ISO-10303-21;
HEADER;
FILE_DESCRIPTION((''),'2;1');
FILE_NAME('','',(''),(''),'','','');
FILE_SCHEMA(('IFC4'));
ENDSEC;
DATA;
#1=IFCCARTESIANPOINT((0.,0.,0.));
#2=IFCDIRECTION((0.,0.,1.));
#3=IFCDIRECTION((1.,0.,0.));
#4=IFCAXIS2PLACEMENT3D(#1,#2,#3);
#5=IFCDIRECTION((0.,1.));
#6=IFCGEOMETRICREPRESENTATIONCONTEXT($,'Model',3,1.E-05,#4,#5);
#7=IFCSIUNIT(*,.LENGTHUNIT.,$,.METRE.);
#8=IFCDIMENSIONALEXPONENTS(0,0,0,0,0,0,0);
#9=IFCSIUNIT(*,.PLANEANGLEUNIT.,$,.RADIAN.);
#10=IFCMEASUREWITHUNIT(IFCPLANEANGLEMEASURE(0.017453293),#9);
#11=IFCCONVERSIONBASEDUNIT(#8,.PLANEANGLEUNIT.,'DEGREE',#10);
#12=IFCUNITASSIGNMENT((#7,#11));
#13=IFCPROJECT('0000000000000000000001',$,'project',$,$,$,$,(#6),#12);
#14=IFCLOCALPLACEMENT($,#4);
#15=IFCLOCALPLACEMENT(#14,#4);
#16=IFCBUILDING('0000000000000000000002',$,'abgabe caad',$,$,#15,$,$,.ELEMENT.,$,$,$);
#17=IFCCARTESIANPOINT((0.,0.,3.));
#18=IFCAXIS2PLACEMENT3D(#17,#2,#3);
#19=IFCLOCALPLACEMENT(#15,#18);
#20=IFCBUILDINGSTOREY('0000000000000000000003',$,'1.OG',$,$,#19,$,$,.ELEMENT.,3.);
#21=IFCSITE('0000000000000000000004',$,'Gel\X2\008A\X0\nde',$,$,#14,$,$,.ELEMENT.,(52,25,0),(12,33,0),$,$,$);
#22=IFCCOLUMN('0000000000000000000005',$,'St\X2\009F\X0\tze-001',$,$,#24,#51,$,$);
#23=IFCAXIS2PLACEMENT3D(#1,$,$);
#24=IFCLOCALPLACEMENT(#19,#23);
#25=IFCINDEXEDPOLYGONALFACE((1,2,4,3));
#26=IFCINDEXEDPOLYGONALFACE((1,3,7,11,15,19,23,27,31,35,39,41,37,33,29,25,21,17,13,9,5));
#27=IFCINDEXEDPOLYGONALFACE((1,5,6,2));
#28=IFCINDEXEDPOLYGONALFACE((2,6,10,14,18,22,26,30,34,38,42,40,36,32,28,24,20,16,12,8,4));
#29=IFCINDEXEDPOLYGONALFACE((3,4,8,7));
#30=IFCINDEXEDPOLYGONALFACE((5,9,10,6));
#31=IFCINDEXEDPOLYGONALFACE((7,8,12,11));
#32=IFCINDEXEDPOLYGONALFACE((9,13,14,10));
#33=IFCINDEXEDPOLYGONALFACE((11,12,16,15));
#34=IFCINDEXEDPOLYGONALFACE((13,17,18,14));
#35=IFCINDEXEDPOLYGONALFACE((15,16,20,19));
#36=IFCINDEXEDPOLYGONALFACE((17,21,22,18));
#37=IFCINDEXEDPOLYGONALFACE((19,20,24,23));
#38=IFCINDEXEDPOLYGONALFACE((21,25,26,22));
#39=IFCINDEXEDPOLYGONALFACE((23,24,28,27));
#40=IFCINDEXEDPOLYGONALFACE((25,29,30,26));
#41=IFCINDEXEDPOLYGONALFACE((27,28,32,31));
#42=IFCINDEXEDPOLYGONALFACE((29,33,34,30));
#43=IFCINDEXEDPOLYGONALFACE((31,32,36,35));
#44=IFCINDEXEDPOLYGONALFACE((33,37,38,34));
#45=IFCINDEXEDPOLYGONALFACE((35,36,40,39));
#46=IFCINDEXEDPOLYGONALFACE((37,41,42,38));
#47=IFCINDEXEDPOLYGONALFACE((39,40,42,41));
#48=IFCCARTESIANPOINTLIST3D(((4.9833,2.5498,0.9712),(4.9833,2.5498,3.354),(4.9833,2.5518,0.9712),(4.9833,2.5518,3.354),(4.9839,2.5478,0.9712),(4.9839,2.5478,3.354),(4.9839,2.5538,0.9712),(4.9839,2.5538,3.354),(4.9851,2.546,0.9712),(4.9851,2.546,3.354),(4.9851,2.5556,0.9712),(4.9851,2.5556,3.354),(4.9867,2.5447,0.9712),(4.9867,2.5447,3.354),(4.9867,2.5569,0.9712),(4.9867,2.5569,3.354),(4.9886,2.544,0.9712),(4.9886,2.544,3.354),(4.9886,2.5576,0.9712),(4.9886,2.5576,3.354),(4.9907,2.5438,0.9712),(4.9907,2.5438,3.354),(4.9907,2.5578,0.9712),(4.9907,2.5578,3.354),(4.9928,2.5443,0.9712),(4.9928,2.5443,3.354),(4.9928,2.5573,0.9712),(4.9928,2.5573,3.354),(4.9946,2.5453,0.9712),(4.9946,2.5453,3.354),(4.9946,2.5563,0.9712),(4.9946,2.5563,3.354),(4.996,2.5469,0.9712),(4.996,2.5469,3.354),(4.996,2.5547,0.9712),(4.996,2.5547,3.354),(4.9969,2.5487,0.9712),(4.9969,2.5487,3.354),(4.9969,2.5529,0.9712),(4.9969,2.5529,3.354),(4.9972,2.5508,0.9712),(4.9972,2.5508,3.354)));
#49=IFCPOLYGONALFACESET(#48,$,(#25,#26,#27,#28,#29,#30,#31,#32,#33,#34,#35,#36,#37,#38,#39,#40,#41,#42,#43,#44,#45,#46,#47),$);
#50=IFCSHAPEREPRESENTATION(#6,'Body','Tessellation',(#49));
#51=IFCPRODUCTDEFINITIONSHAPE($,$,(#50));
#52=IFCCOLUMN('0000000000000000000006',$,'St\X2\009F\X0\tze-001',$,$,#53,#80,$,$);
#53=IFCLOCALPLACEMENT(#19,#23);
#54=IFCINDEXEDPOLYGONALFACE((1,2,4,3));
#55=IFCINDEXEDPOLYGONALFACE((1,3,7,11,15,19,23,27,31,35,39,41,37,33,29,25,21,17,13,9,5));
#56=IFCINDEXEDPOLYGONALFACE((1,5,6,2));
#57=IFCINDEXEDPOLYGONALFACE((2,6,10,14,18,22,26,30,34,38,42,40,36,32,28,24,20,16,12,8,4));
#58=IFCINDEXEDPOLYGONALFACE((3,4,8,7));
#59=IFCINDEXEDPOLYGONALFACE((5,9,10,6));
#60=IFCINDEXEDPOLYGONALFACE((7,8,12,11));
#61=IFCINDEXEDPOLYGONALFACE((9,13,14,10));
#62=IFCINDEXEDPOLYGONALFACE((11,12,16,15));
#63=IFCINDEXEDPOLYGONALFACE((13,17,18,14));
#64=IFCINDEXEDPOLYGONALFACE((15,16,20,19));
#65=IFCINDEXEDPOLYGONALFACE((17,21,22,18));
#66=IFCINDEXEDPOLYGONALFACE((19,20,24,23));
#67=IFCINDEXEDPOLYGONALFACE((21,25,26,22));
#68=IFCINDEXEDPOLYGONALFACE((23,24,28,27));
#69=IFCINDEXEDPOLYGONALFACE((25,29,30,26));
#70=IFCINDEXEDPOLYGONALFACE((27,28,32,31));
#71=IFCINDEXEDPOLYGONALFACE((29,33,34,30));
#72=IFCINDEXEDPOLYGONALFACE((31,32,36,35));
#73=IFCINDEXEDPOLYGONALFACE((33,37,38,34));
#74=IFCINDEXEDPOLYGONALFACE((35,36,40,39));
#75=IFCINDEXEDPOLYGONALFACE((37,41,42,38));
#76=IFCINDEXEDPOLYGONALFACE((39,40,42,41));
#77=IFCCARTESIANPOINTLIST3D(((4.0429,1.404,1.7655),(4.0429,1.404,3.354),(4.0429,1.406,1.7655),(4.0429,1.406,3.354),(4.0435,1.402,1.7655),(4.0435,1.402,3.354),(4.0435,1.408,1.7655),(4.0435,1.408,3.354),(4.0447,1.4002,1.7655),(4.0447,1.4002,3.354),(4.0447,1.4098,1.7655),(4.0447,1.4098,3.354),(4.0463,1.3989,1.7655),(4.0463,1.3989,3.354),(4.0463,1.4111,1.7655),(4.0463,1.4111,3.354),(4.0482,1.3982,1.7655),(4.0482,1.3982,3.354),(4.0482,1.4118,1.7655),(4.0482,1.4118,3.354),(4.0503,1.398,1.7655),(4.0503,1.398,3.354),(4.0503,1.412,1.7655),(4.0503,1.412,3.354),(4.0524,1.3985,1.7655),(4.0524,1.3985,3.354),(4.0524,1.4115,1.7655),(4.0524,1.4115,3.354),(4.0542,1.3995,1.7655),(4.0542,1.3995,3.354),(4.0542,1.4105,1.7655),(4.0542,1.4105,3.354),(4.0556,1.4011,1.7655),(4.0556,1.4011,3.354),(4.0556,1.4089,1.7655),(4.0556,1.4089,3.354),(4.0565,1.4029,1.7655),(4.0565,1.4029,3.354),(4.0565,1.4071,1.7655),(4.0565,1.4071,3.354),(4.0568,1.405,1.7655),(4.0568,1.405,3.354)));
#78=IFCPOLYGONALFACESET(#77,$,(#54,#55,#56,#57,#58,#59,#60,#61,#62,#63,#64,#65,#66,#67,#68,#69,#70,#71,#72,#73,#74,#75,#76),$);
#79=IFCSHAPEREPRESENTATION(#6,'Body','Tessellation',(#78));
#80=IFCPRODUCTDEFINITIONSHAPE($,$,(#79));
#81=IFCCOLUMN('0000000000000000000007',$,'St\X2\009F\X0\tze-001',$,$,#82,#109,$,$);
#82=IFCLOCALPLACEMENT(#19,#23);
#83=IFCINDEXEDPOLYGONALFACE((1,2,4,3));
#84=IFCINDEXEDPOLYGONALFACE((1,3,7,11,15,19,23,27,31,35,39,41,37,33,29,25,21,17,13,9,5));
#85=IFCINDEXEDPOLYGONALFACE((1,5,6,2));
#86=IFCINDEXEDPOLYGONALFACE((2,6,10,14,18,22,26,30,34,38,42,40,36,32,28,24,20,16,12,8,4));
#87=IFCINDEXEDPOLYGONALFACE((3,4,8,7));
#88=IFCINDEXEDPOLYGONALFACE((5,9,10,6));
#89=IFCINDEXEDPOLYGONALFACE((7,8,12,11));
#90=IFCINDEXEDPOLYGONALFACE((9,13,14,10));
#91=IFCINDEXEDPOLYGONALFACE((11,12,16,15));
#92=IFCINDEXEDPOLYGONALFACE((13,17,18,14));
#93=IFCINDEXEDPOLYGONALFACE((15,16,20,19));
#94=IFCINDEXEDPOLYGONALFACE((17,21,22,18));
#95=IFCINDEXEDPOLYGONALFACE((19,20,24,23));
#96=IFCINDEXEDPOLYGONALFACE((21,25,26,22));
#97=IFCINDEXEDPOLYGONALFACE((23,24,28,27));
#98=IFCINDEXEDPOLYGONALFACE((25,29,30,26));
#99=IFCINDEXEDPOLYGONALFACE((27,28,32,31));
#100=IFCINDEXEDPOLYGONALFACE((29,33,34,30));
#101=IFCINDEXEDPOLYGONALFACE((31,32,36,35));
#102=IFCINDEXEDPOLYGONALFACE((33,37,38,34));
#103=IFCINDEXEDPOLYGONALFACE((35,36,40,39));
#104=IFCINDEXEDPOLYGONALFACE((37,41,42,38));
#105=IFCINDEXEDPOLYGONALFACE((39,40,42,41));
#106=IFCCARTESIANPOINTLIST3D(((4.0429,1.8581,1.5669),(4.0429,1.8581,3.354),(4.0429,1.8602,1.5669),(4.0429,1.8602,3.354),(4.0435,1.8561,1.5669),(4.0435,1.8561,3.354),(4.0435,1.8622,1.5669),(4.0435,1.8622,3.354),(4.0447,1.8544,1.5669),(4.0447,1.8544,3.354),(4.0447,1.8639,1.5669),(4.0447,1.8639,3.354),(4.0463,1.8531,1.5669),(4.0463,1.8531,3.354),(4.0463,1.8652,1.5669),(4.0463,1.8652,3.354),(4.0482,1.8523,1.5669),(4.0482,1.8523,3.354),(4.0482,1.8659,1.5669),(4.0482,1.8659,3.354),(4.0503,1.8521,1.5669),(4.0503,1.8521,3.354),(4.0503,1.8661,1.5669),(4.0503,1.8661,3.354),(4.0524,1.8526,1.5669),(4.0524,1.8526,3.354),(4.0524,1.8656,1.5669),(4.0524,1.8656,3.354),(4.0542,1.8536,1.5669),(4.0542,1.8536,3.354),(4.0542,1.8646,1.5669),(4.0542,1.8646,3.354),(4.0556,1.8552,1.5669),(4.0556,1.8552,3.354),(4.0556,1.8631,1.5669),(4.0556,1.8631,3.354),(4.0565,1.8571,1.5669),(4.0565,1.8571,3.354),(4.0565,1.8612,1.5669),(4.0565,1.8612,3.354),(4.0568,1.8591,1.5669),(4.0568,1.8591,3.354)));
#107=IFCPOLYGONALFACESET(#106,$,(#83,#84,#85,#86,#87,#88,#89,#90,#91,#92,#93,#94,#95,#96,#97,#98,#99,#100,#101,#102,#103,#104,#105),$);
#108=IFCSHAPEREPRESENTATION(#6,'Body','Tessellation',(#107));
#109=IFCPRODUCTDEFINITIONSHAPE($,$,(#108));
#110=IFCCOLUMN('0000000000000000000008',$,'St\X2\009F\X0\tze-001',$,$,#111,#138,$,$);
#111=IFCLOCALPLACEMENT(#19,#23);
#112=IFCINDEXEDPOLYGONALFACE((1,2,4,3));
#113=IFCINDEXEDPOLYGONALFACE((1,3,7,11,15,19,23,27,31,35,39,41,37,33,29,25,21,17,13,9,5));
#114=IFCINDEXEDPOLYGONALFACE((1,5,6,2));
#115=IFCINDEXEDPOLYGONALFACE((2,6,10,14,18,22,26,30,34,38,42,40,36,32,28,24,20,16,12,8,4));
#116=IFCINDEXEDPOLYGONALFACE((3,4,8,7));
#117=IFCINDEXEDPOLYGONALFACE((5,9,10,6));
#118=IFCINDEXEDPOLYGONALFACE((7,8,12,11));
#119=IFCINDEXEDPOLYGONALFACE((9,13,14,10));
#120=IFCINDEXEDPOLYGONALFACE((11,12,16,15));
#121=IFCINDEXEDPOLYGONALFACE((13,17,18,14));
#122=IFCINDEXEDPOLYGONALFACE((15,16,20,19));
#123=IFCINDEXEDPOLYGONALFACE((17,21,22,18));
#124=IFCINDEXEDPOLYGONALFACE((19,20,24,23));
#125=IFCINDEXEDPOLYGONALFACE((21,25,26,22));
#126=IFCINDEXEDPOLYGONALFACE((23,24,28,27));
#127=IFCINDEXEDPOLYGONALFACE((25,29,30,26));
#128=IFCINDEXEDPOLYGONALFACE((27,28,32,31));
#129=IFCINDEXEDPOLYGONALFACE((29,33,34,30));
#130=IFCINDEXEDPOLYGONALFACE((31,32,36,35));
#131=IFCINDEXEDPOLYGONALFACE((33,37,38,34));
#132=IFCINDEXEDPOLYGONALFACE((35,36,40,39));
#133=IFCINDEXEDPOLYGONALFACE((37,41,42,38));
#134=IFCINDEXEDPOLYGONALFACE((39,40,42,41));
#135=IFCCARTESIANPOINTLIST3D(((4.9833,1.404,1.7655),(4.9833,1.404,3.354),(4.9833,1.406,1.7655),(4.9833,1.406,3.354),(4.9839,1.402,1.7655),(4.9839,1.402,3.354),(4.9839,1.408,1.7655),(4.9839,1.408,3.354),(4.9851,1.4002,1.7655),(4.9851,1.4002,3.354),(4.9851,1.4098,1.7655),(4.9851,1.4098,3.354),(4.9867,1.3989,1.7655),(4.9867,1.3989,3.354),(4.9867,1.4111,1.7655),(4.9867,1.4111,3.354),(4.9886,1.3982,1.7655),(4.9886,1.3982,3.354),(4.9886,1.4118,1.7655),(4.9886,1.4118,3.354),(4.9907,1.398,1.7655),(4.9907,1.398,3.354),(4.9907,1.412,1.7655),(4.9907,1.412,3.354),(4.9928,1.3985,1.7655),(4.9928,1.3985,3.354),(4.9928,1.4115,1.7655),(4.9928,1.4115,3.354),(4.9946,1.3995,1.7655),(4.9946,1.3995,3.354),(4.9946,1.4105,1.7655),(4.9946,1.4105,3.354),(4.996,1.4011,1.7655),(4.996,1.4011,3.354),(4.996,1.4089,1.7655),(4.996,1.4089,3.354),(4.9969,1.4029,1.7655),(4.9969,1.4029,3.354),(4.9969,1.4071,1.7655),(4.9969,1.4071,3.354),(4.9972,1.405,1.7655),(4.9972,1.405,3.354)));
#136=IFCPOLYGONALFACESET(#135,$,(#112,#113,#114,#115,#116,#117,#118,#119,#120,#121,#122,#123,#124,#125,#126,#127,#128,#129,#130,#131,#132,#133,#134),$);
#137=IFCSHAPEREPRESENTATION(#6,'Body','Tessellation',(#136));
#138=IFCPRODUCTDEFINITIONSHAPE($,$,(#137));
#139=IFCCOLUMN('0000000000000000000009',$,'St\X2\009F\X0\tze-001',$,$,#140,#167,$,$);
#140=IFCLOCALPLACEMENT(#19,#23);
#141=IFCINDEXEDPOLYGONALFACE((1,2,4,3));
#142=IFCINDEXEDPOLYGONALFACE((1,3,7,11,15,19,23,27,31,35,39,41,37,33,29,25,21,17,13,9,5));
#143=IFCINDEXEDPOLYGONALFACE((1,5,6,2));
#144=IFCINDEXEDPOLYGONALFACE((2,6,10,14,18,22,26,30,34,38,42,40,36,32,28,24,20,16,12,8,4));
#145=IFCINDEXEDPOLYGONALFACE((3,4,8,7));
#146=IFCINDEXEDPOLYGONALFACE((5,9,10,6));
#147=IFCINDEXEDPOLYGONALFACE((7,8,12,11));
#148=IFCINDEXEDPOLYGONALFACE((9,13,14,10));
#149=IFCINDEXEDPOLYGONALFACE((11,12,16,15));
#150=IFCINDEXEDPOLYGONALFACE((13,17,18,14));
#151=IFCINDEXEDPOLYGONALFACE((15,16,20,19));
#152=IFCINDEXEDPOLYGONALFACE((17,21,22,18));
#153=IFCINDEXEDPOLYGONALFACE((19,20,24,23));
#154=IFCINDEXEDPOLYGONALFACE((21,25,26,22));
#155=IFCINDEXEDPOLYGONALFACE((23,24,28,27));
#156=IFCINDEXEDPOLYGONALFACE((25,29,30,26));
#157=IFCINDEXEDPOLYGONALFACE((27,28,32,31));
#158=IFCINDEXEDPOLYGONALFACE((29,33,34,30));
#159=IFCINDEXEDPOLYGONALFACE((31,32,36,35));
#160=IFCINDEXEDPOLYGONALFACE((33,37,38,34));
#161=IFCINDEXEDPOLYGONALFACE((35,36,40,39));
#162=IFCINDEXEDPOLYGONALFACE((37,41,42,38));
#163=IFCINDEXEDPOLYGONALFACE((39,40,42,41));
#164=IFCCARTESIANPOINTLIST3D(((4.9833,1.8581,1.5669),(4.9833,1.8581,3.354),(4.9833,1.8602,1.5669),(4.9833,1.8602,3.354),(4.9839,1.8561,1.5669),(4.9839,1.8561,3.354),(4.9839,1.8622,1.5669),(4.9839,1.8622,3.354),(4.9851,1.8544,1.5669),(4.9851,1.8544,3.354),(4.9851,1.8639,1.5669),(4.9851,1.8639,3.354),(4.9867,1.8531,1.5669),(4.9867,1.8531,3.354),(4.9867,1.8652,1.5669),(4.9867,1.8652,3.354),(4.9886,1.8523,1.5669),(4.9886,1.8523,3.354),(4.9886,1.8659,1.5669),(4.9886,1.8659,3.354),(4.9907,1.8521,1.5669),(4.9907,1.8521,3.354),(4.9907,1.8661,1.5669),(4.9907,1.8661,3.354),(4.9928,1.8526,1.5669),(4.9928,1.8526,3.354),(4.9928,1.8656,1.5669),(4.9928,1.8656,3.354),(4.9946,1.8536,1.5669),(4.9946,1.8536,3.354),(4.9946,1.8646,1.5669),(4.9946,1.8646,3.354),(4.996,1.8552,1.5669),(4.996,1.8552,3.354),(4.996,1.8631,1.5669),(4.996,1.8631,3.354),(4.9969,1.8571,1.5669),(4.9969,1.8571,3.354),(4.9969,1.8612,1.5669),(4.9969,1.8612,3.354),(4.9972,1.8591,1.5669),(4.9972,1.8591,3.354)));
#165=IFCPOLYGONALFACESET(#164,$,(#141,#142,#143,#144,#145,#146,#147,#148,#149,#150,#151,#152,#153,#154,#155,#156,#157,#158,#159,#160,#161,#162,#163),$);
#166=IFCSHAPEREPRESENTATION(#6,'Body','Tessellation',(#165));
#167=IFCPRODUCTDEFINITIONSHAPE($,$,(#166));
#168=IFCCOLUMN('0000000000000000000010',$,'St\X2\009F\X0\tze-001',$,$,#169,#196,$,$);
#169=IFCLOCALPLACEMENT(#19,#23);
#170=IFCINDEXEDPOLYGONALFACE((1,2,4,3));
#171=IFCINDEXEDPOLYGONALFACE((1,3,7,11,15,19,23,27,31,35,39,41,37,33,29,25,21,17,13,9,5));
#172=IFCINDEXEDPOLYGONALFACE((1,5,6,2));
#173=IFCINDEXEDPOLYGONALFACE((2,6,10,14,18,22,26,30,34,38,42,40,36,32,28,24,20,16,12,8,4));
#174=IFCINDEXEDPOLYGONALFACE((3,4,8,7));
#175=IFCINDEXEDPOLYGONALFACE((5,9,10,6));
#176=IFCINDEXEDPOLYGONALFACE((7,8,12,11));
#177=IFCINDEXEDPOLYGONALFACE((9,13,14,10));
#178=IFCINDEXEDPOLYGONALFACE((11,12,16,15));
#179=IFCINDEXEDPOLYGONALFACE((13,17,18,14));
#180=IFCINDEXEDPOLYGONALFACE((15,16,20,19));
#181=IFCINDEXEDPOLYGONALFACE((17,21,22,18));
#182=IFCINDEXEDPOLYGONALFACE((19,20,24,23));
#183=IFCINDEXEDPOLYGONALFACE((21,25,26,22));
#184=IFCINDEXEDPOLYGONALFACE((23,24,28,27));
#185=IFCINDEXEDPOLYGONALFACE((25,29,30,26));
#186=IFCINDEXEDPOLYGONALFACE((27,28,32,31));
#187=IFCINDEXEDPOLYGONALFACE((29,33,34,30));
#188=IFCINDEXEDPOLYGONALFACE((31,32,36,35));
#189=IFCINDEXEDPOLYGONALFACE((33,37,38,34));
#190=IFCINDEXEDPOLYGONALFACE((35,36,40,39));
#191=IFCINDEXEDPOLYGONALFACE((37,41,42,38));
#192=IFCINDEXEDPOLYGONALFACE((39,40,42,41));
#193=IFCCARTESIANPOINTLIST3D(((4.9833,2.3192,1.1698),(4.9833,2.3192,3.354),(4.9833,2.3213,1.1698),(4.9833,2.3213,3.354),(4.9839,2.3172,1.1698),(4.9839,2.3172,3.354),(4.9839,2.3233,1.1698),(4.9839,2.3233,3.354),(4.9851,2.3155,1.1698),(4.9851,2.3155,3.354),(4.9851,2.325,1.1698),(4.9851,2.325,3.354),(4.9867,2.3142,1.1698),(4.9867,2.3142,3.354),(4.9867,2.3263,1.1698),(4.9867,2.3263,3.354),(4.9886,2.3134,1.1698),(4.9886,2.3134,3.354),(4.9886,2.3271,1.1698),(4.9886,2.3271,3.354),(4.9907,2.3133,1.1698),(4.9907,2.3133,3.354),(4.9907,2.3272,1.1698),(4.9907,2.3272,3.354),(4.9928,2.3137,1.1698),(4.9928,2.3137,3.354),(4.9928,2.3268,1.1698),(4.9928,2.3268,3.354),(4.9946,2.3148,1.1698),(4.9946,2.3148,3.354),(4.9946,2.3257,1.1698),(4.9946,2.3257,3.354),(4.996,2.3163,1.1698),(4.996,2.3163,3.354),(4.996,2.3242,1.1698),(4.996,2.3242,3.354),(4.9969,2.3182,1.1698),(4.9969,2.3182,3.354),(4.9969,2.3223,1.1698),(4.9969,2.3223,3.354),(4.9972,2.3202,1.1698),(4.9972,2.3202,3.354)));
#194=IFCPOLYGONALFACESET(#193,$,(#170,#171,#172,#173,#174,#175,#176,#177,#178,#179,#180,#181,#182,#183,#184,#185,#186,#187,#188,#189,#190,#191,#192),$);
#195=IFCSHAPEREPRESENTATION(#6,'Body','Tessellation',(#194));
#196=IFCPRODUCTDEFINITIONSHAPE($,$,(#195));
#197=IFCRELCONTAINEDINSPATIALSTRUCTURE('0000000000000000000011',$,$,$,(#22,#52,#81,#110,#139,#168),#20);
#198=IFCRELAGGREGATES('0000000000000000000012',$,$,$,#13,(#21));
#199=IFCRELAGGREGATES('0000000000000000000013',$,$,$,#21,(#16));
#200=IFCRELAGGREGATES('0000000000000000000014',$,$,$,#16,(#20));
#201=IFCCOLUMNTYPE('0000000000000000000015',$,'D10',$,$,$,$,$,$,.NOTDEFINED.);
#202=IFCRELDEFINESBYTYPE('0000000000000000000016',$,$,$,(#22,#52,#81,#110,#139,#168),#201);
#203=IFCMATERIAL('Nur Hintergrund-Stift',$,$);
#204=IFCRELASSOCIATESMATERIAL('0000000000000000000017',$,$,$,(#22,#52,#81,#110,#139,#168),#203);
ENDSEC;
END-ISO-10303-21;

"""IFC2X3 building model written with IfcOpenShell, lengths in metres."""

from ifc_helpers import new_model, entity, si_unit, converted_unit, direction, frame, origin_with_axes, origin_2d_with_axis, place, context, project, spatial, circle, extrude, material, type_object, element, save


model = new_model("IFC2X3")

# Units and contexts
model_context = context("Model", 3, precision=1e-05, world=origin_with_axes(), true_north=direction((0.0, 1.0)))
ifc_project = project(units=[si_unit("LENGTHUNIT", "METRE"), converted_unit("PLANEANGLEUNIT", "DEGREE", entity("IfcPlaneAngleMeasure", 0.017453293), si_unit("PLANEANGLEUNIT", "RADIAN"), dimensions=[0, 0, 0, 0, 0, 0, 0])], contexts=[model_context])

# Site, building, storey
site_placement = place(None, origin_with_axes())
site = spatial("IfcSite", under=ifc_project, at=site_placement, Name="Gel\u008ande", CompositionType="ELEMENT", RefLatitude=(52, 25, 0), RefLongitude=(12, 33, 0))
building_placement = place(site_placement, origin_with_axes())
building = spatial("IfcBuilding", under=site, at=building_placement, Name="abgabe caad", CompositionType="ELEMENT")
storey_placement = place(building_placement, frame((0.0, 0.0, 3.0), z_axis=(0.0, 0.0, 1.0), x_axis=(1.0, 0.0, 0.0)))
storey = spatial("IfcBuildingStorey", under=building, at=storey_placement, Name="1.OG", CompositionType="ELEMENT", Elevation=3.0)

# Columns
ifc_material_1 = material(Name="Nur Hintergrund-Stift")
column_type = type_object("IfcColumnType", Name="D10", PredefinedType="NOTDEFINED")
column_1_placement = place(storey_placement, frame((4.9902, 2.5508, 0.9712), z_axis=(0.0, 0.0, 1.0), x_axis=(1.0, 0.0, 0.0)))
element("IfcColumn", 1, at=column_1_placement, inside=storey, type_object=column_type, material=ifc_material_1, Name="St\u009ftze-001", context=model_context, shape_type="SweptSolid", body=[
    extrude(circle(Radius=0.007, at=origin_2d_with_axis()), origin_with_axes(), (0.0, 0.0, 1.0), 2.3828),
])
column_2_placement = place(storey_placement, frame((4.0498, 1.405, 1.7655), z_axis=(0.0, 0.0, 1.0), x_axis=(1.0, 0.0, 0.0)))
element("IfcColumn", 2, at=column_2_placement, inside=storey, type_object=column_type, material=ifc_material_1, Name="St\u009ftze-001", context=model_context, shape_type="SweptSolid", body=[
    extrude(circle(Radius=0.007, at=origin_2d_with_axis()), origin_with_axes(), (0.0, 0.0, 1.0), 1.5885),
])
column_3_placement = place(storey_placement, frame((4.0498, 1.8591, 1.5669), z_axis=(0.0, 0.0, 1.0), x_axis=(1.0, 0.0, 0.0)))
element("IfcColumn", 3, at=column_3_placement, inside=storey, type_object=column_type, material=ifc_material_1, Name="St\u009ftze-001", context=model_context, shape_type="SweptSolid", body=[
    extrude(circle(Radius=0.007, at=origin_2d_with_axis()), origin_with_axes(), (0.0, 0.0, 1.0), 1.7871),
])
column_4_placement = place(storey_placement, frame((4.9902, 1.405, 1.7655), z_axis=(0.0, 0.0, 1.0), x_axis=(1.0, 0.0, 0.0)))
element("IfcColumn", 4, at=column_4_placement, inside=storey, type_object=column_type, material=ifc_material_1, Name="St\u009ftze-001", context=model_context, shape_type="SweptSolid", body=[
    extrude(circle(Radius=0.007, at=origin_2d_with_axis()), origin_with_axes(), (0.0, 0.0, 1.0), 1.5885),
])
column_5_placement = place(storey_placement, frame((4.9902, 1.8591, 1.5669), z_axis=(0.0, 0.0, 1.0), x_axis=(1.0, 0.0, 0.0)))
element("IfcColumn", 5, at=column_5_placement, inside=storey, type_object=column_type, material=ifc_material_1, Name="St\u009ftze-001", context=model_context, shape_type="SweptSolid", body=[
    extrude(circle(Radius=0.007, at=origin_2d_with_axis()), origin_with_axes(), (0.0, 0.0, 1.0), 1.7871),
])
column_6_placement = place(storey_placement, frame((4.9902, 2.3202, 1.1698), z_axis=(0.0, 0.0, 1.0), x_axis=(1.0, 0.0, 0.0)))
element("IfcColumn", 6, at=column_6_placement, inside=storey, type_object=column_type, material=ifc_material_1, Name="St\u009ftze-001", context=model_context, shape_type="SweptSolid", body=[
    extrude(circle(Radius=0.007, at=origin_2d_with_axis()), origin_with_axes(), (0.0, 0.0, 1.0), 2.1842),
])

save(model, "model.ifc")
